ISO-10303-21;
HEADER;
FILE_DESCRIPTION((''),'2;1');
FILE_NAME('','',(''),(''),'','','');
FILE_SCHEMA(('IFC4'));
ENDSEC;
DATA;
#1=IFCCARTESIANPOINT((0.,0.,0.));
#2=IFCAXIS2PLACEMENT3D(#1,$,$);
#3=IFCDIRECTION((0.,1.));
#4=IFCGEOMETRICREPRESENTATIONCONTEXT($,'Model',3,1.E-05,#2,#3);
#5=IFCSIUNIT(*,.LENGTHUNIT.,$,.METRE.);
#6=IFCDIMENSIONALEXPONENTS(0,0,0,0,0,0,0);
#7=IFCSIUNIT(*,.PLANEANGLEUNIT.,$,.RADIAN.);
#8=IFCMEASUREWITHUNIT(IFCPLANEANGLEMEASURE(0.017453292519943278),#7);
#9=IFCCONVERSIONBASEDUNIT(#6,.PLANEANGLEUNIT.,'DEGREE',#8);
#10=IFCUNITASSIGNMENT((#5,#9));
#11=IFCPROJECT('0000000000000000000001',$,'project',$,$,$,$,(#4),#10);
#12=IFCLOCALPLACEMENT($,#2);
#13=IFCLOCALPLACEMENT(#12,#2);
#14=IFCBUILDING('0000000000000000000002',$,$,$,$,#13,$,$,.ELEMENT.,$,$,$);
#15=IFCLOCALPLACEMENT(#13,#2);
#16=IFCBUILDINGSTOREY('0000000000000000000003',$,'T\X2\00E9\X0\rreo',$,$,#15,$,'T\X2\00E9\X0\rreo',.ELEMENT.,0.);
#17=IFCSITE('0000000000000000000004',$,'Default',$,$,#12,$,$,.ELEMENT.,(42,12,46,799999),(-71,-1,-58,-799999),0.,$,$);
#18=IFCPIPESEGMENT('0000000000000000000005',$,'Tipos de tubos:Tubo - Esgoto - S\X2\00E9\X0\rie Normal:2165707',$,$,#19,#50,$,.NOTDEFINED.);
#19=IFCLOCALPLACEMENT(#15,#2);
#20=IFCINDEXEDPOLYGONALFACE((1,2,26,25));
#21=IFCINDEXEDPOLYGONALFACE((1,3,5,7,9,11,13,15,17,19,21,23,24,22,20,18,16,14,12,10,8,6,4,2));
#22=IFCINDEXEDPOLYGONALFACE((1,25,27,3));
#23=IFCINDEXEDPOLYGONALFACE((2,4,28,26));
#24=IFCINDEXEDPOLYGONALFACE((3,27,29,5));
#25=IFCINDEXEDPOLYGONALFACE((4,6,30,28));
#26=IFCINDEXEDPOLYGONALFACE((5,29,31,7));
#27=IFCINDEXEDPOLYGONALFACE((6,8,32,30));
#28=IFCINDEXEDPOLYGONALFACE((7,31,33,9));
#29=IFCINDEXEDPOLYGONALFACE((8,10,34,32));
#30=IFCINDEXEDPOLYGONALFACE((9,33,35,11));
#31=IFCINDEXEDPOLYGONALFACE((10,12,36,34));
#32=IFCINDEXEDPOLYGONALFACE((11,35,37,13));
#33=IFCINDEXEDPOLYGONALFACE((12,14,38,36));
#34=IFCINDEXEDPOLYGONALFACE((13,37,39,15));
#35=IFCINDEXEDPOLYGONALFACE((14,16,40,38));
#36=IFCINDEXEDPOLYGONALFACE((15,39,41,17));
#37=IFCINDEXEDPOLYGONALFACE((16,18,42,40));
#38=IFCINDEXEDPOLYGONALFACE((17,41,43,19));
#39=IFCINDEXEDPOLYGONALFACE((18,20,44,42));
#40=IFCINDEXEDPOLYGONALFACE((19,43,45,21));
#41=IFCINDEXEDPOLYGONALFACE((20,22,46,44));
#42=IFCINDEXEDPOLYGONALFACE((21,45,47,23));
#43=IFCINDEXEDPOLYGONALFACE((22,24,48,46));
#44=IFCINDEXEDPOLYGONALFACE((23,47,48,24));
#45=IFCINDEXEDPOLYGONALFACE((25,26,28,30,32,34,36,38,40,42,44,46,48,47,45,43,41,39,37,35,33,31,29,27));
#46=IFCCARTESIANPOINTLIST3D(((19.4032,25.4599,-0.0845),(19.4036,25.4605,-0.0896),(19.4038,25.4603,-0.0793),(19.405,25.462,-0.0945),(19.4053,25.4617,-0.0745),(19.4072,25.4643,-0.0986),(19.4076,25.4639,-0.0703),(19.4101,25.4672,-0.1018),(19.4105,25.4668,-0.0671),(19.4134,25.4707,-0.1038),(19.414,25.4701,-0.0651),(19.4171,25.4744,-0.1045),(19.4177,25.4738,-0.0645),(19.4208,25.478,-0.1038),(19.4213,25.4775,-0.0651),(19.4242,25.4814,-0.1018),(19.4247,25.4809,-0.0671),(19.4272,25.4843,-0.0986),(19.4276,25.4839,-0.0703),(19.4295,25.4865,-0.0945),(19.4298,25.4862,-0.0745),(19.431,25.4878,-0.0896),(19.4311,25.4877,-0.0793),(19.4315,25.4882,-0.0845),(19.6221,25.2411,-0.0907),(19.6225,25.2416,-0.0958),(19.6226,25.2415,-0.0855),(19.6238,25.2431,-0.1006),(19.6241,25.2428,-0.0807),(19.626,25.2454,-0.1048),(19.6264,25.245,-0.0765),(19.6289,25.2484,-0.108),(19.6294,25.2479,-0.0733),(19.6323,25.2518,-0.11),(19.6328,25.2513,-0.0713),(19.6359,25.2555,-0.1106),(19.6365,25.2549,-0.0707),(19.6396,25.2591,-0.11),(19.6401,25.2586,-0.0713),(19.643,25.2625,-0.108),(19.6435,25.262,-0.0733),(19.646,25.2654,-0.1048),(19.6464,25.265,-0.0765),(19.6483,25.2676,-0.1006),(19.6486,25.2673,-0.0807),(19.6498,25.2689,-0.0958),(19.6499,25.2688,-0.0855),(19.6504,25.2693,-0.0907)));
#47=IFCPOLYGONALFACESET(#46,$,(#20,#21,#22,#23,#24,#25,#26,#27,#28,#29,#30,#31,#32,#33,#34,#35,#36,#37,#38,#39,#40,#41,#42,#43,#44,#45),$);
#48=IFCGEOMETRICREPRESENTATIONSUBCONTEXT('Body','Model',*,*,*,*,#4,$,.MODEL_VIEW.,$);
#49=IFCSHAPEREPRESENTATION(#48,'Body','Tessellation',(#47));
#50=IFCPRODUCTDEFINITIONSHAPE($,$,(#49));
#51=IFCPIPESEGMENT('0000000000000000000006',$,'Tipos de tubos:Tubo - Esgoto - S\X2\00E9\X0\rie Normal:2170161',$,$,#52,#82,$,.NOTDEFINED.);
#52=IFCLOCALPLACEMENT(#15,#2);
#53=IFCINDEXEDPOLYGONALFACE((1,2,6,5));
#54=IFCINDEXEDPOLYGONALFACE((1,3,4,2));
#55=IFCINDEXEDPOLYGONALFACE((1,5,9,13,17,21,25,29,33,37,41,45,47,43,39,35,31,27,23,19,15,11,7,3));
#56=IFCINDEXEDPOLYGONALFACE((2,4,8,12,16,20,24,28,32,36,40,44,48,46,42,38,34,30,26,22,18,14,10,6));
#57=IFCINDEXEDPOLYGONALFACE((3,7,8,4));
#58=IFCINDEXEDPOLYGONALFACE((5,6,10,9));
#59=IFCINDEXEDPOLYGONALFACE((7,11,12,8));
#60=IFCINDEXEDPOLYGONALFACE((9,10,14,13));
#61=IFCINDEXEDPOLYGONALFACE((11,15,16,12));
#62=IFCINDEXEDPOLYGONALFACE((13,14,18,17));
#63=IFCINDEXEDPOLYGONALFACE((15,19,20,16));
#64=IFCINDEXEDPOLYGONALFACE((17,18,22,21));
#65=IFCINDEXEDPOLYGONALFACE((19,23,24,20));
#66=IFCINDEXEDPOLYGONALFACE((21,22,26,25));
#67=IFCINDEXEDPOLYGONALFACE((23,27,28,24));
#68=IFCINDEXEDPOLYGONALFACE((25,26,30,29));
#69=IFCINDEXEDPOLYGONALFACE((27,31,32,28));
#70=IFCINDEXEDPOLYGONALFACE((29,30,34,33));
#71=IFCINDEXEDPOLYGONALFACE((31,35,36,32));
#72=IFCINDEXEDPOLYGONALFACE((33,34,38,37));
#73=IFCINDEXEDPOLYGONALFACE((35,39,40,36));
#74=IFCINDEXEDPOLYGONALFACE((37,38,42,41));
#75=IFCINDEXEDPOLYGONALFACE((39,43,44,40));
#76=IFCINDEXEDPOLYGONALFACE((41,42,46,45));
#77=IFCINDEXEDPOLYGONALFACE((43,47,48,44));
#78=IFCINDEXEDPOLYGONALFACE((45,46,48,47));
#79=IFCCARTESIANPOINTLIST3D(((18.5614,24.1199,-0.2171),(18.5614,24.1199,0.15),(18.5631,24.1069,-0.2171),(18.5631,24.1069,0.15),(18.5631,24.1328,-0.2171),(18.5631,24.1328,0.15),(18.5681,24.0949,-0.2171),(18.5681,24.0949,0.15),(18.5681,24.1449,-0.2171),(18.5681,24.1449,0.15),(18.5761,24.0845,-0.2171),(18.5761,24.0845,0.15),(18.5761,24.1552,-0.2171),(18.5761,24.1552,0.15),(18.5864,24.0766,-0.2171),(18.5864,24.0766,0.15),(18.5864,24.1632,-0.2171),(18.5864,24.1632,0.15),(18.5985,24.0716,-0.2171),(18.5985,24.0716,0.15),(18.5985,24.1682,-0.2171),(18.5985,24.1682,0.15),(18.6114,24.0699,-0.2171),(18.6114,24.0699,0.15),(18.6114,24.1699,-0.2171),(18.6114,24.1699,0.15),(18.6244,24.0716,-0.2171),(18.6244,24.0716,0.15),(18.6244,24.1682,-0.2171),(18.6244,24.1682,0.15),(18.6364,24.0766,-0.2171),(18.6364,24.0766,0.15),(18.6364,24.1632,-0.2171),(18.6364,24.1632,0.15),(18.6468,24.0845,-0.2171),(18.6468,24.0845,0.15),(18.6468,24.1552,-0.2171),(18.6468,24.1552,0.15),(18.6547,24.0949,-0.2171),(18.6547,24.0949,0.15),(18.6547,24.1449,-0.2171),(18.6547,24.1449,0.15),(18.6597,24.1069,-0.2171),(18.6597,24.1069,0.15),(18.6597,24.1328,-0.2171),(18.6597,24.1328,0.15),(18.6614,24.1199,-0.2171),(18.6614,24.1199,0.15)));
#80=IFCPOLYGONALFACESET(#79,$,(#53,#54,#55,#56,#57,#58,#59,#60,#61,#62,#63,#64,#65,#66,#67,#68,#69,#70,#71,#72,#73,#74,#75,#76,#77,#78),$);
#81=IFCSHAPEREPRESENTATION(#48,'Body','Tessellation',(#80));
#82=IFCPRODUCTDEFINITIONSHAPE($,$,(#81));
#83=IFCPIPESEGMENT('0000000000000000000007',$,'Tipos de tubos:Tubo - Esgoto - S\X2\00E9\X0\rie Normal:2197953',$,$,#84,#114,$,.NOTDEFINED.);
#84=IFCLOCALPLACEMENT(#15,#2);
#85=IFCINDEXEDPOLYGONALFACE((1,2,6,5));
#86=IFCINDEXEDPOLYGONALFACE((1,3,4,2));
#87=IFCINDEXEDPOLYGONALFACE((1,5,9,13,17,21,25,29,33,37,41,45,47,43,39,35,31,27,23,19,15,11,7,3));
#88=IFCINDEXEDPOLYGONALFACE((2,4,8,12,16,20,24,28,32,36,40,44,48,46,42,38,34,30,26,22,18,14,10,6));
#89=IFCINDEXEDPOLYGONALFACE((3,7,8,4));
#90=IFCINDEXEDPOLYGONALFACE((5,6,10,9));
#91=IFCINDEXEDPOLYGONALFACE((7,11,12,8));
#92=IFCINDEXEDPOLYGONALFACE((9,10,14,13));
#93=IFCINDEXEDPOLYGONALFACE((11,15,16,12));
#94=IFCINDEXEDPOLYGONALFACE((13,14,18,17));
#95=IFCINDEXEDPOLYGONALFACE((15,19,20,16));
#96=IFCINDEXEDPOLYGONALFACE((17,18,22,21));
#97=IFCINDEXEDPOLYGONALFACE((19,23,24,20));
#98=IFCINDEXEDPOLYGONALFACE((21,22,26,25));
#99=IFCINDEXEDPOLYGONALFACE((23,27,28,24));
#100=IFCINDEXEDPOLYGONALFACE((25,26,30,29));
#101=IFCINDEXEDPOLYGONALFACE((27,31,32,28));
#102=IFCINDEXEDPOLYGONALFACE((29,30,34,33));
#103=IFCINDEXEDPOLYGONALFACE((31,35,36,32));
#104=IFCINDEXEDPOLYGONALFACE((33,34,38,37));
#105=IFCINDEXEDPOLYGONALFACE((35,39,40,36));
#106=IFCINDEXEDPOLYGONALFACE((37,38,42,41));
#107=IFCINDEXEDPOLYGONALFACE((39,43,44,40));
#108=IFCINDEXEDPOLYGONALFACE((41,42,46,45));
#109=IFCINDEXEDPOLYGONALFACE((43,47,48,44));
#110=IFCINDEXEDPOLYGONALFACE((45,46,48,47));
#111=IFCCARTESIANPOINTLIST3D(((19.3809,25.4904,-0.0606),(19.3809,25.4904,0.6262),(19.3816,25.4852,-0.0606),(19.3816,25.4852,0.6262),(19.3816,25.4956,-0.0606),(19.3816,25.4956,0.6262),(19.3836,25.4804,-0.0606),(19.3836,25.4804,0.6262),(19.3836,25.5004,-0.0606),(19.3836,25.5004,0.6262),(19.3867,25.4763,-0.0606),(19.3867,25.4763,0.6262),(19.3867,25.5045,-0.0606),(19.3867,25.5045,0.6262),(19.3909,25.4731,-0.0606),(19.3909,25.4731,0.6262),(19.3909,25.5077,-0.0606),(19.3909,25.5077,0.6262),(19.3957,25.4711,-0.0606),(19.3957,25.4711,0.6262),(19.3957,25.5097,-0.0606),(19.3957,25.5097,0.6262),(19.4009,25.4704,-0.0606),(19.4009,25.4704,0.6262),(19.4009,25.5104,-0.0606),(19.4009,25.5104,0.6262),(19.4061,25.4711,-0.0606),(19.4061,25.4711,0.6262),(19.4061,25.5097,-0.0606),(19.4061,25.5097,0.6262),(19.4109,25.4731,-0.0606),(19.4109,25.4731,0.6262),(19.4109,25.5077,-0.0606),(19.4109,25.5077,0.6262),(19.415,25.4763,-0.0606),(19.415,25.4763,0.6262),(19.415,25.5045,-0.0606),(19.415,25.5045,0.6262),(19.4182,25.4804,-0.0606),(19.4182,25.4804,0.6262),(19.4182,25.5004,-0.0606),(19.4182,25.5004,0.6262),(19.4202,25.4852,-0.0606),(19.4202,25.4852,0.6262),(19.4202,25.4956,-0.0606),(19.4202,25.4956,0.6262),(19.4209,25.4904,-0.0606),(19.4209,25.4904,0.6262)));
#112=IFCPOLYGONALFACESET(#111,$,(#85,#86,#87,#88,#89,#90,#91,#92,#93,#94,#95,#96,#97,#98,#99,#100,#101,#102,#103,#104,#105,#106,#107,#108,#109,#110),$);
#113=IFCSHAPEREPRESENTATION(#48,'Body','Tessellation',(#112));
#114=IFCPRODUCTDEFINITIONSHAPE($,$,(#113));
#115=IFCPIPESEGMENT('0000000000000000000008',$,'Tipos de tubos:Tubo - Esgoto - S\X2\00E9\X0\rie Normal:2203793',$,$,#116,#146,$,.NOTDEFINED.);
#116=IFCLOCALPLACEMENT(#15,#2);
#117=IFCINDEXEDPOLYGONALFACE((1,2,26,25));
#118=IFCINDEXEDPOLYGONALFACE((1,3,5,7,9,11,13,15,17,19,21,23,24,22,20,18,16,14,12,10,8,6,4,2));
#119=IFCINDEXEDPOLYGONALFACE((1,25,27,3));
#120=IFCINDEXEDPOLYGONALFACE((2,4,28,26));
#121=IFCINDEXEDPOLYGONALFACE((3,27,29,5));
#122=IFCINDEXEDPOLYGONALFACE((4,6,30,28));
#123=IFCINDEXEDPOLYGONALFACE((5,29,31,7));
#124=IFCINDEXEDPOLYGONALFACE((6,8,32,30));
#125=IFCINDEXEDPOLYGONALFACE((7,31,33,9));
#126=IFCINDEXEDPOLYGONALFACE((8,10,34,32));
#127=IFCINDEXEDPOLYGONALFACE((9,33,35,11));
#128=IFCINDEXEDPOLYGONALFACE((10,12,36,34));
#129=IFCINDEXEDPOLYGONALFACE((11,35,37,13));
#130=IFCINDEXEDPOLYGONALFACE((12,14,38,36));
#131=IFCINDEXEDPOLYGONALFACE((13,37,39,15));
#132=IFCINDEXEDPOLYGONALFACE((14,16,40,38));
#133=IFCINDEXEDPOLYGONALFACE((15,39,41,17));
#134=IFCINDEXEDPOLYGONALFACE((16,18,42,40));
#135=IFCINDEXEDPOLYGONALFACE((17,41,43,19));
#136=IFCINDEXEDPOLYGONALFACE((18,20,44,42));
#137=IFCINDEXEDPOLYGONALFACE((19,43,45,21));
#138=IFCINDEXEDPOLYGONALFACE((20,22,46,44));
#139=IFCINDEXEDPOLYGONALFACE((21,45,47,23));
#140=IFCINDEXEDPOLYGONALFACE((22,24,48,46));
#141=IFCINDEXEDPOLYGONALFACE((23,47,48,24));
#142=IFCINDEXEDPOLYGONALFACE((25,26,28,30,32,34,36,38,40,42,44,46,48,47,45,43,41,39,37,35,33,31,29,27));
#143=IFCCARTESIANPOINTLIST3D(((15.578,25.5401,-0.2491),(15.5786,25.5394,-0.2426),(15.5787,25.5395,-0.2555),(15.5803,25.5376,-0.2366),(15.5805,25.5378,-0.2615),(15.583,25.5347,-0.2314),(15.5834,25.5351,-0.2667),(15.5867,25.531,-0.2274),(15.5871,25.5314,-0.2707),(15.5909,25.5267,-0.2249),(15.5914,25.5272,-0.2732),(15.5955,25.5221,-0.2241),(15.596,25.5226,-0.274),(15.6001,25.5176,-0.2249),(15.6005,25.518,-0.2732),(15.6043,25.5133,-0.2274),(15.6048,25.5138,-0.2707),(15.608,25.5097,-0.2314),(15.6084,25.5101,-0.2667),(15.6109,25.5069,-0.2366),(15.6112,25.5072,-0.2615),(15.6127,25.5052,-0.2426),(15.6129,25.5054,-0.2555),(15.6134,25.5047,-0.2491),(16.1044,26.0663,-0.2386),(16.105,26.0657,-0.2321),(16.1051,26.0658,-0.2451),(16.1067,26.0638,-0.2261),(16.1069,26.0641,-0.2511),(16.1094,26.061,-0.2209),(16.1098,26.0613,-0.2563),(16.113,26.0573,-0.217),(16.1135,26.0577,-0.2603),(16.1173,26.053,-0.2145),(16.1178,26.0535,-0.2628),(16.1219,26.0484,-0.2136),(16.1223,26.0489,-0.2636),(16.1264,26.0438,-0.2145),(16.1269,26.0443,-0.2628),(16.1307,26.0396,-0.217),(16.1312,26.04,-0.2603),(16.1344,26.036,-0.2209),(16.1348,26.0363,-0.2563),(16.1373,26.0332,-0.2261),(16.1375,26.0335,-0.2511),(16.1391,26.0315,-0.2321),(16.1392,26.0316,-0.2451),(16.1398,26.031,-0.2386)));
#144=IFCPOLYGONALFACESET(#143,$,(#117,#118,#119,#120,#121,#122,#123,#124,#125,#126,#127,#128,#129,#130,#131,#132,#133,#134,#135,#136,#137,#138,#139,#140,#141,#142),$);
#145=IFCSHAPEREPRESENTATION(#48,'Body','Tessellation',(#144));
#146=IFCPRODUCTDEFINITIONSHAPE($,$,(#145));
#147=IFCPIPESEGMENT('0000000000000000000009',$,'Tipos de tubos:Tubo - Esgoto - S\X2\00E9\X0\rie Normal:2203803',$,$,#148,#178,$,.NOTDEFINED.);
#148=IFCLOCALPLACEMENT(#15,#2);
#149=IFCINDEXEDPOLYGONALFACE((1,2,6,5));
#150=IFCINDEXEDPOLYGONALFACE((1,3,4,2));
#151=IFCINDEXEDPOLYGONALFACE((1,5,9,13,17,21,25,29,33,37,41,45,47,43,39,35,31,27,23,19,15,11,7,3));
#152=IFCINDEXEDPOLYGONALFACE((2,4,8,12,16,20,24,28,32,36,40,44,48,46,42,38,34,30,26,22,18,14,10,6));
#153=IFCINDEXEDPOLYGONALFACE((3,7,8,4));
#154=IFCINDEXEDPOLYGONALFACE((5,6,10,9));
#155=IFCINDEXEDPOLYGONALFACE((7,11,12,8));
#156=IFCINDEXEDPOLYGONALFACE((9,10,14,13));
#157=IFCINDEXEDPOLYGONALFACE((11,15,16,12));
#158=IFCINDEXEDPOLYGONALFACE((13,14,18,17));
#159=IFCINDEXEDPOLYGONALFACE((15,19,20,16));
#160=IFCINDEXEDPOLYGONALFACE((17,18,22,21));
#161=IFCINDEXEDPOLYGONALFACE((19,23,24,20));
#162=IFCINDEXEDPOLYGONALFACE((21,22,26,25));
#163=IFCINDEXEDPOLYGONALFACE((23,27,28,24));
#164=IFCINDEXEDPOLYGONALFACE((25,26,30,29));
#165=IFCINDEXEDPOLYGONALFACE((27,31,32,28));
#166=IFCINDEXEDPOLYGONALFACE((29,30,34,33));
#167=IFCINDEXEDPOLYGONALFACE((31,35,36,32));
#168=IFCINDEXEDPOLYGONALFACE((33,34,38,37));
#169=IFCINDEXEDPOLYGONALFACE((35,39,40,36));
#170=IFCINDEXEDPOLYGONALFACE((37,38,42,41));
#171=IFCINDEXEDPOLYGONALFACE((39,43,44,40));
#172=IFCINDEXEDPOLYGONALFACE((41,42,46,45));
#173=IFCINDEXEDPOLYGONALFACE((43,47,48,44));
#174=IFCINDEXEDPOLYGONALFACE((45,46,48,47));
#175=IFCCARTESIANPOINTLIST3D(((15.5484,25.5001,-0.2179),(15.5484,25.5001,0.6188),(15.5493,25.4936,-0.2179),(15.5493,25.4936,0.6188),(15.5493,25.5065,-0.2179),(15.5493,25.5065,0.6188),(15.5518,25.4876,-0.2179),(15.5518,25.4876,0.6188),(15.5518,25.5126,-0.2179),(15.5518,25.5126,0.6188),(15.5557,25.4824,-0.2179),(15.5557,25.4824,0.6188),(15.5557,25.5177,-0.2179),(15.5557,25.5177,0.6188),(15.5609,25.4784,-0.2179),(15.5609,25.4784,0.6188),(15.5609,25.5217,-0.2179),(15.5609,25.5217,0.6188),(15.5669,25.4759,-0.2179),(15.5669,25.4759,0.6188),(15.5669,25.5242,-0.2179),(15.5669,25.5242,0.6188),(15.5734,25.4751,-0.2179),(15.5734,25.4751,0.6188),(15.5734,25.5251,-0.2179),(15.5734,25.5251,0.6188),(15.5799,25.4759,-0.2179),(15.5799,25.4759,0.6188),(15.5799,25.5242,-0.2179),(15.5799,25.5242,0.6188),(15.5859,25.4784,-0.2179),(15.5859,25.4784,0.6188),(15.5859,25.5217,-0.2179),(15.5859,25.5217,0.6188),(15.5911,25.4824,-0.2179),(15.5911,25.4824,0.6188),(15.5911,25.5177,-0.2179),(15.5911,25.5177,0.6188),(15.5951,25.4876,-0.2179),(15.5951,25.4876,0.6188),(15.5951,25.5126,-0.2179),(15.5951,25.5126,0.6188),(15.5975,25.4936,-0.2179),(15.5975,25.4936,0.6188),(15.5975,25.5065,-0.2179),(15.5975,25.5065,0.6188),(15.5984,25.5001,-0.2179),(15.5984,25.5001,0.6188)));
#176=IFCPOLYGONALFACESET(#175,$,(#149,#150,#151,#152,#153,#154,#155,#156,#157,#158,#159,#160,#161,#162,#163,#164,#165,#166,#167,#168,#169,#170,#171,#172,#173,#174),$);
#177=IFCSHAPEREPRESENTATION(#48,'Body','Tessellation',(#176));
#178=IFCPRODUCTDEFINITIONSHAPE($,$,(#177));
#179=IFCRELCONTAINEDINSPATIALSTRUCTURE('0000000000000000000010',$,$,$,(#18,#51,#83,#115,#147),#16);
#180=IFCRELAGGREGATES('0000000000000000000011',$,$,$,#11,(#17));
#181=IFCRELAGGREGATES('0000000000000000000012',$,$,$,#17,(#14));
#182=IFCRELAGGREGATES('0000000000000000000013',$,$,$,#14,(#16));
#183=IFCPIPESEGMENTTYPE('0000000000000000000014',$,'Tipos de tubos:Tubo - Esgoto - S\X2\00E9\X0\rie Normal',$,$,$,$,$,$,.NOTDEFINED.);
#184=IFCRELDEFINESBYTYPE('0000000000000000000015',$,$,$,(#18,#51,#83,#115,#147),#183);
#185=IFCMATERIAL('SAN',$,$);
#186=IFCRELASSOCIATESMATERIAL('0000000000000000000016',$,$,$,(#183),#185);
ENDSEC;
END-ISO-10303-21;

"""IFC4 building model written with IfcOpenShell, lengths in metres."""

from ifc_helpers import new_model, entity, si_unit, converted_unit, direction, frame, origin, place, context, subcontext, project, spatial, arc, indexed_curve, outline, extrude, material, type_object, element, save


model = new_model("IFC4")

# Units and contexts
model_context = context("Model", 3, precision=1e-05, world=origin(), true_north=direction((0.0, 1.0)))
body_context = subcontext(model_context, "Body", "Model", "MODEL_VIEW")
ifc_project = project(units=[si_unit("LENGTHUNIT", "METRE"), converted_unit("PLANEANGLEUNIT", "DEGREE", entity("IfcPlaneAngleMeasure", 0.017453292519943278), si_unit("PLANEANGLEUNIT", "RADIAN"), dimensions=[0, 0, 0, 0, 0, 0, 0])], contexts=[model_context])

# Site, building, storey
site_placement = place(None, origin())
site = spatial("IfcSite", under=ifc_project, at=site_placement, Name="Default", CompositionType="ELEMENT", RefLatitude=(42, 12, 46, 799999), RefLongitude=(-71, -1, -58, -799999), RefElevation=0.0)
building_placement = place(site_placement, origin())
building = spatial("IfcBuilding", under=site, at=building_placement, CompositionType="ELEMENT")
storey_placement = place(building_placement, origin())
storey = spatial("IfcBuildingStorey", under=building, at=storey_placement, Name="Térreo", LongName="Térreo", CompositionType="ELEMENT", Elevation=0.0)

# Pipe segments
ifc_material_1 = material(Name="SAN")
pipe_segment_type_1 = type_object("IfcPipeSegmentType", Name="Tipos de tubos:Tubo - Esgoto - Série Normal", PredefinedType="NOTDEFINED", material=ifc_material_1)
pipe_segment_1_placement = place(storey_placement, origin())
element("IfcPipeSegment", 1, at=pipe_segment_1_placement, inside=storey, type_object=pipe_segment_type_1, Name="Tipos de tubos:Tubo - Esgoto - Série Normal:2165707", PredefinedType="NOTDEFINED", context=body_context, shape_type="SweptSolid", body=[
    extrude(outline(indexed_curve([(0.02, 0.0), (0.0141, 0.0141), (0.0, 0.02), (-0.0141, 0.0141), (-0.02, 0.0), (-0.0141, -0.0141), (0.0, -0.02), (0.0141, -0.0141)], segments=[arc(1, 2, 3), arc(3, 4, 5), arc(5, 6, 7), arc(7, 8, 1)], self_intersect=False)), frame((19.6362, 25.2552, -0.0907), z_axis=(-0.706913, 0.707018, 0.019996), x_axis=(-0.707159, -0.707054, 0.0)), (0.0, 0.0, 1.0), 0.3096),
])
pipe_segment_2_placement = place(storey_placement, origin())
element("IfcPipeSegment", 2, at=pipe_segment_2_placement, inside=storey, type_object=pipe_segment_type_1, Name="Tipos de tubos:Tubo - Esgoto - Série Normal:2170161", PredefinedType="NOTDEFINED", context=body_context, shape_type="SweptSolid", body=[
    extrude(outline(indexed_curve([(0.05, 0.0), (0.0354, 0.0354), (0.0, 0.05), (-0.0354, 0.0354), (-0.05, 0.0), (-0.0354, -0.0354), (0.0, -0.05), (0.0354, -0.0354)], segments=[arc(1, 2, 3), arc(3, 4, 5), arc(5, 6, 7), arc(7, 8, 1)], self_intersect=False)), frame((18.6114, 24.1199, -0.2171)), (0.0, 0.0, 1.0), 0.3671),
])
pipe_segment_3_placement = place(storey_placement, origin())
element("IfcPipeSegment", 3, at=pipe_segment_3_placement, inside=storey, type_object=pipe_segment_type_1, Name="Tipos de tubos:Tubo - Esgoto - Série Normal:2197953", PredefinedType="NOTDEFINED", context=body_context, shape_type="SweptSolid", body=[
    extrude(outline(indexed_curve([(0.02, 0.0), (0.0141, 0.0141), (0.0, 0.02), (-0.0141, 0.0141), (-0.02, 0.0), (-0.0141, -0.0141), (0.0, -0.02), (0.0141, -0.0141)], segments=[arc(1, 2, 3), arc(3, 4, 5), arc(5, 6, 7), arc(7, 8, 1)], self_intersect=False)), frame((19.4009, 25.4904, -0.0606)), (0.0, 0.0, 1.0), 0.6868),
])
pipe_segment_4_placement = place(storey_placement, origin())
element("IfcPipeSegment", 4, at=pipe_segment_4_placement, inside=storey, type_object=pipe_segment_type_1, Name="Tipos de tubos:Tubo - Esgoto - Série Normal:2203793", PredefinedType="NOTDEFINED", context=body_context, shape_type="SweptSolid", body=[
    extrude(outline(indexed_curve([(0.025, 0.0), (0.0177, 0.0177), (0.0, 0.025), (-0.0177, 0.0177), (-0.025, 0.0), (-0.0177, -0.0177), (0.0, -0.025), (0.0177, -0.0177)], segments=[arc(1, 2, 3), arc(3, 4, 5), arc(5, 6, 7), arc(7, 8, 1)], self_intersect=False)), frame((15.5957, 25.5224, -0.2491), z_axis=(0.707109, 0.706965, 0.014029), x_axis=(-0.707035, 0.707179, 0.0)), (0.0, 0.0, 1.0), 0.7444),
])
pipe_segment_5_placement = place(storey_placement, origin())
element("IfcPipeSegment", 5, at=pipe_segment_5_placement, inside=storey, type_object=pipe_segment_type_1, Name="Tipos de tubos:Tubo - Esgoto - Série Normal:2203803", PredefinedType="NOTDEFINED", context=body_context, shape_type="SweptSolid", body=[
    extrude(outline(indexed_curve([(0.025, 0.0), (0.0177, 0.0177), (0.0, 0.025), (-0.0177, 0.0177), (-0.025, 0.0), (-0.0177, -0.0177), (0.0, -0.025), (0.0177, -0.0177)], segments=[arc(1, 2, 3), arc(3, 4, 5), arc(5, 6, 7), arc(7, 8, 1)], self_intersect=False)), frame((15.5734, 25.5001, -0.2179)), (0.0, 0.0, 1.0), 0.8367),
])

save(model, "model.ifc")
